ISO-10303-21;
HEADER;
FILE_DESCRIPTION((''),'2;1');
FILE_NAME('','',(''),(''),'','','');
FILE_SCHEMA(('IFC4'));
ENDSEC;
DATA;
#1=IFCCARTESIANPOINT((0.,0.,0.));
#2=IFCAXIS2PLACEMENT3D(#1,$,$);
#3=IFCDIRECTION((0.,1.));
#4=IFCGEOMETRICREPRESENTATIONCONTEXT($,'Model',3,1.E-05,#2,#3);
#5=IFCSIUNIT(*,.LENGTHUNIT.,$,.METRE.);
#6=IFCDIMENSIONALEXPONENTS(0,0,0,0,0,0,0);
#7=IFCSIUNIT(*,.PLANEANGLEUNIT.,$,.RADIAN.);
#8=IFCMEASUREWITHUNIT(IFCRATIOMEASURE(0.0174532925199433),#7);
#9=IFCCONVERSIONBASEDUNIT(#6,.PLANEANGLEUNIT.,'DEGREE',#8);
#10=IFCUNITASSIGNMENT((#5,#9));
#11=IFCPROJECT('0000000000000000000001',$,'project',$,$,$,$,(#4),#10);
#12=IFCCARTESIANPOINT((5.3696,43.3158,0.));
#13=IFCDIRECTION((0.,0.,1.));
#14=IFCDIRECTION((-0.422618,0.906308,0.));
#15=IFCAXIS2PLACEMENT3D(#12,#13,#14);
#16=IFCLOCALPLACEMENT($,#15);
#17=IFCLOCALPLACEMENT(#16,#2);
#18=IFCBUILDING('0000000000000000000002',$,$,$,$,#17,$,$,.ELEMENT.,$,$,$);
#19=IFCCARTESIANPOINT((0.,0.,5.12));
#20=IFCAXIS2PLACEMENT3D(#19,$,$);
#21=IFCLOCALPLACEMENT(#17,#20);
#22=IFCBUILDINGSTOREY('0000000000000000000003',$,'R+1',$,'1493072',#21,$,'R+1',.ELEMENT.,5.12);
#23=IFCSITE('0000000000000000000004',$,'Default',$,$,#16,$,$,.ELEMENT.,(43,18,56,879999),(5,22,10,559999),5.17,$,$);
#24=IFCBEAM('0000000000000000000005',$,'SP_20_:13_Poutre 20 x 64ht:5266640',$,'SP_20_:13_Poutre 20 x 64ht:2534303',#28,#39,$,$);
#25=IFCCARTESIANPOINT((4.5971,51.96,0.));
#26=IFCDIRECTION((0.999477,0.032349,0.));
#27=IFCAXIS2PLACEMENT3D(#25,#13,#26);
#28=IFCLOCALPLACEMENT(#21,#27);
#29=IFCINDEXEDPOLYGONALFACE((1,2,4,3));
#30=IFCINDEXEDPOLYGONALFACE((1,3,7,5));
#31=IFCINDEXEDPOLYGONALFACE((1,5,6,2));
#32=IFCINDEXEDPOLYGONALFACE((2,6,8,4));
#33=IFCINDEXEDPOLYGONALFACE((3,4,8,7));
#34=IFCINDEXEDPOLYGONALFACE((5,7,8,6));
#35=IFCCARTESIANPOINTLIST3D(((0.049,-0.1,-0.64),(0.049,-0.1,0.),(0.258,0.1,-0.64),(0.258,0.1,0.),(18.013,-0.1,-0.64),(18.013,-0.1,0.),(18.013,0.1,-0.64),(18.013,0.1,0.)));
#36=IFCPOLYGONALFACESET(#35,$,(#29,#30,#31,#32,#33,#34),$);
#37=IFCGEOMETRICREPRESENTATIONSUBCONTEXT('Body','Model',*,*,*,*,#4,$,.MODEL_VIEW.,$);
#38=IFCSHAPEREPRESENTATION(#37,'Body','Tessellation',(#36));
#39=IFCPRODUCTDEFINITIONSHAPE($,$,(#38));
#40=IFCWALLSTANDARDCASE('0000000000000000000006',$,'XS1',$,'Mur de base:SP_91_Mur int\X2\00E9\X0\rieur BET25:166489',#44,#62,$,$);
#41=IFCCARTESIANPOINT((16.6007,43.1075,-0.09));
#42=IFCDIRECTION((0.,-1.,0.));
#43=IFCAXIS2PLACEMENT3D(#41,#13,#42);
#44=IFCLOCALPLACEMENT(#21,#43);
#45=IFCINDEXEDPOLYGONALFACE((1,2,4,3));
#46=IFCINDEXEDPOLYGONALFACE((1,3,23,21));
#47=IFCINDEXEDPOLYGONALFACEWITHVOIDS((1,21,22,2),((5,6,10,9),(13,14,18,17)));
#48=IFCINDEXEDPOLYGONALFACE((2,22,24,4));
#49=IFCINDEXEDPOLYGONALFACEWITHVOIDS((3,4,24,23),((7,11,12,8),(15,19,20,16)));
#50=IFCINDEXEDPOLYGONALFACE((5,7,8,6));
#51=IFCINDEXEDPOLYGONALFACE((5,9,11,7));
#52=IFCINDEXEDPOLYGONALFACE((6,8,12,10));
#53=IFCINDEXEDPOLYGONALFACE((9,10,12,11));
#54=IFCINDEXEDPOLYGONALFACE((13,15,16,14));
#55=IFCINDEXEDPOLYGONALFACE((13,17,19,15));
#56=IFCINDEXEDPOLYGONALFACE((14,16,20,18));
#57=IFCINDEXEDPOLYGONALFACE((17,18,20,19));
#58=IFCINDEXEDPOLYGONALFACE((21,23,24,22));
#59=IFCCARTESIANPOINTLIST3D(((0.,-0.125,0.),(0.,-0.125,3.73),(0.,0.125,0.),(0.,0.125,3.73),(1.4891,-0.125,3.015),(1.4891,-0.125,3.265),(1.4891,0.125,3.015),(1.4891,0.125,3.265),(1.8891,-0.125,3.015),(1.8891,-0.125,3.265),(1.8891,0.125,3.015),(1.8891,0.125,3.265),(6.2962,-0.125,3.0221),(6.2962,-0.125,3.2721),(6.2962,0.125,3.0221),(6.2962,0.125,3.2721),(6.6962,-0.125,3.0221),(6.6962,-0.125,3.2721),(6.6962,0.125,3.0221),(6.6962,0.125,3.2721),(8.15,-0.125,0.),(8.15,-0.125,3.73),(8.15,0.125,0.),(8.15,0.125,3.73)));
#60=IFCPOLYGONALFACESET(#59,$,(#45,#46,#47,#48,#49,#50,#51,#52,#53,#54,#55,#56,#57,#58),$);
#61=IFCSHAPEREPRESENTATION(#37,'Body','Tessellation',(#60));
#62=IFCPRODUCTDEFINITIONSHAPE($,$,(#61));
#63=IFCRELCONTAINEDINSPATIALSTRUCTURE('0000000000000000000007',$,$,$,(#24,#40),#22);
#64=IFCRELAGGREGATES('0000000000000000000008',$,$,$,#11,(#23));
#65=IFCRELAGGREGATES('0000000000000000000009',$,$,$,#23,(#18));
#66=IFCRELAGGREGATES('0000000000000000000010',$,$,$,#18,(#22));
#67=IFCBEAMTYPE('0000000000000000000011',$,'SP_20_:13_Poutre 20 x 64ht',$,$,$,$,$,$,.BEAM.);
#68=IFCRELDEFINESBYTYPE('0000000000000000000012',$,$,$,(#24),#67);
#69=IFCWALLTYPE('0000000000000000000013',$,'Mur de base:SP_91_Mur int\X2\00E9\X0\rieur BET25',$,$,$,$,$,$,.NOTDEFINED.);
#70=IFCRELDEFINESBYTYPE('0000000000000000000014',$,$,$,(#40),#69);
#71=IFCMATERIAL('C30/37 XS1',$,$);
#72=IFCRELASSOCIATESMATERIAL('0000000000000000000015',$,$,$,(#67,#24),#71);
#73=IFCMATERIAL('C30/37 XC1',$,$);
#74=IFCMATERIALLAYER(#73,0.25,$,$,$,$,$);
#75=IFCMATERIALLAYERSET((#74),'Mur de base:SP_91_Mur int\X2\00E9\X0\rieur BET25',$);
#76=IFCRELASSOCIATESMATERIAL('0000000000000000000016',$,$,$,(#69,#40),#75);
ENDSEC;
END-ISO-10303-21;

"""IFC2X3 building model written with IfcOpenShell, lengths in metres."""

from ifc_helpers import new_model, entity, si_unit, converted_unit, direction, frame, frame_2d, origin, place, context, subcontext, project, spatial, rectangle, extrude, clip, halfspace, material, layer, layer_set, layer_usage, type_object, element, save


model = new_model("IFC2X3")

# Units and contexts
model_context = context("Model", 3, precision=1e-05, world=origin(), true_north=direction((0.0, 1.0)))
body_context = subcontext(model_context, "Body", "Model", "MODEL_VIEW")
ifc_project = project(units=[si_unit("LENGTHUNIT", "METRE"), converted_unit("PLANEANGLEUNIT", "DEGREE", entity("IfcRatioMeasure", 0.0174532925199433), si_unit("PLANEANGLEUNIT", "RADIAN"), dimensions=[0, 0, 0, 0, 0, 0, 0])], contexts=[model_context])

# Site, building, storey
site_placement = place(None, frame((5.3696, 43.3158, 0.0), z_axis=(0.0, 0.0, 1.0), x_axis=(-0.422618, 0.906308, 0.0)))
site = spatial("IfcSite", under=ifc_project, at=site_placement, Name="Default", CompositionType="ELEMENT", RefLatitude=(43, 18, 56, 879999), RefLongitude=(5, 22, 10, 559999), RefElevation=5.17)
building_placement = place(site_placement, origin())
building = spatial("IfcBuilding", under=site, at=building_placement, CompositionType="ELEMENT")
storey_placement = place(building_placement, frame((0.0, 0.0, 5.12)))
storey = spatial("IfcBuildingStorey", under=building, at=storey_placement, Name="R+1", ObjectType="1493072", LongName="R+1", CompositionType="ELEMENT", Elevation=5.12)

# Beam
ifc_material_1 = material(Name="C30/37 XS1")
beam_type_1 = type_object("IfcBeamType", Name="SP_20_:13_Poutre 20 x 64ht", PredefinedType="BEAM", material=ifc_material_1)
beam_1_placement = place(storey_placement, frame((4.5971, 51.96, 0.0), z_axis=(0.0, 0.0, 1.0), x_axis=(0.999477, 0.032349, 0.0)))
element("IfcBeam", 1, at=beam_1_placement, inside=storey, type_object=beam_type_1, material=ifc_material_1, Name="SP_20_:13_Poutre 20 x 64ht:5266640", ObjectType="SP_20_:13_Poutre 20 x 64ht:2534303", context=body_context, shape_type="Clipping", body=[
    clip(extrude(rectangle(XDim=0.64, YDim=0.2, at=frame_2d((0.0, 0.0), x_axis=(1.0, 0.0))), frame((0.049, 0.0, -0.32), z_axis=(1.0, 0.0, 0.0), x_axis=(0.0, 0.0, -1.0)), (0.0, 0.0, 1.0), 17.964), halfspace(frame((-0.0404, -0.1855, 0.0), z_axis=(-0.691354, 0.722516, 0.0), x_axis=(-0.722516, -0.691354, 0.0)), False)),
])

# Shared definitions
ifc_material_2 = material(Name="C30/37 XC1")
ifc_layer_1 = layer(ifc_material_2, 0.25)
ifc_layer_set_1 = layer_set([ifc_layer_1], Name="Mur de base:SP_91_Mur intérieur BET25")
wall_type_1 = type_object("IfcWallType", Name="Mur de base:SP_91_Mur intérieur BET25", PredefinedType="NOTDEFINED", material=ifc_layer_set_1)

# Wall, openings
ifc_layer_usage_1 = layer_usage(ifc_layer_set_1, "AXIS2", "NEGATIVE", 0.125)
wall_1_placement = place(storey_placement, frame((16.6007, 43.1075, -0.09), z_axis=(0.0, 0.0, 1.0), x_axis=(0.0, -1.0, 0.0)))
wall_1 = element("IfcWallStandardCase", 2, at=wall_1_placement, inside=storey, type_object=wall_type_1, material=ifc_layer_usage_1, Name="XS1", ObjectType="Mur de base:SP_91_Mur intérieur BET25:166489", context=body_context, shape_type="SweptSolid", body=[
    extrude(rectangle(XDim=8.15, YDim=0.25, at=frame_2d((4.075, 0.0), x_axis=(-1.0, 0.0))), origin(), (0.0, 0.0, 1.0), 3.73),
])
opening_1_placement = place(wall_1_placement, origin())
element("IfcOpeningElement", 3, at=opening_1_placement, cuts=wall_1, ObjectType="Opening", context=body_context, shape_type="SweptSolid", body=[
    extrude(rectangle(XDim=0.25, YDim=0.4, at=frame_2d((0.0, 0.0), x_axis=(0.0, 1.0))), frame((6.4962, -1.399, 3.1471), z_axis=(0.0, 1.0, 0.0), x_axis=(-1.0, 0.0, 0.0)), (0.0, 0.0, 1.0), 3.048),
])
opening_2_placement = place(wall_1_placement, origin())
element("IfcOpeningElement", 4, at=opening_2_placement, cuts=wall_1, ObjectType="Opening", context=body_context, shape_type="SweptSolid", body=[
    extrude(rectangle(XDim=0.25, YDim=0.4, at=frame_2d((0.0, 0.0), x_axis=(0.0, 1.0))), frame((1.6891, -1.399, 3.14), z_axis=(0.0, 1.0, 0.0), x_axis=(-1.0, 0.0, 0.0)), (0.0, 0.0, 1.0), 3.048),
])

save(model, "model.ifc")
